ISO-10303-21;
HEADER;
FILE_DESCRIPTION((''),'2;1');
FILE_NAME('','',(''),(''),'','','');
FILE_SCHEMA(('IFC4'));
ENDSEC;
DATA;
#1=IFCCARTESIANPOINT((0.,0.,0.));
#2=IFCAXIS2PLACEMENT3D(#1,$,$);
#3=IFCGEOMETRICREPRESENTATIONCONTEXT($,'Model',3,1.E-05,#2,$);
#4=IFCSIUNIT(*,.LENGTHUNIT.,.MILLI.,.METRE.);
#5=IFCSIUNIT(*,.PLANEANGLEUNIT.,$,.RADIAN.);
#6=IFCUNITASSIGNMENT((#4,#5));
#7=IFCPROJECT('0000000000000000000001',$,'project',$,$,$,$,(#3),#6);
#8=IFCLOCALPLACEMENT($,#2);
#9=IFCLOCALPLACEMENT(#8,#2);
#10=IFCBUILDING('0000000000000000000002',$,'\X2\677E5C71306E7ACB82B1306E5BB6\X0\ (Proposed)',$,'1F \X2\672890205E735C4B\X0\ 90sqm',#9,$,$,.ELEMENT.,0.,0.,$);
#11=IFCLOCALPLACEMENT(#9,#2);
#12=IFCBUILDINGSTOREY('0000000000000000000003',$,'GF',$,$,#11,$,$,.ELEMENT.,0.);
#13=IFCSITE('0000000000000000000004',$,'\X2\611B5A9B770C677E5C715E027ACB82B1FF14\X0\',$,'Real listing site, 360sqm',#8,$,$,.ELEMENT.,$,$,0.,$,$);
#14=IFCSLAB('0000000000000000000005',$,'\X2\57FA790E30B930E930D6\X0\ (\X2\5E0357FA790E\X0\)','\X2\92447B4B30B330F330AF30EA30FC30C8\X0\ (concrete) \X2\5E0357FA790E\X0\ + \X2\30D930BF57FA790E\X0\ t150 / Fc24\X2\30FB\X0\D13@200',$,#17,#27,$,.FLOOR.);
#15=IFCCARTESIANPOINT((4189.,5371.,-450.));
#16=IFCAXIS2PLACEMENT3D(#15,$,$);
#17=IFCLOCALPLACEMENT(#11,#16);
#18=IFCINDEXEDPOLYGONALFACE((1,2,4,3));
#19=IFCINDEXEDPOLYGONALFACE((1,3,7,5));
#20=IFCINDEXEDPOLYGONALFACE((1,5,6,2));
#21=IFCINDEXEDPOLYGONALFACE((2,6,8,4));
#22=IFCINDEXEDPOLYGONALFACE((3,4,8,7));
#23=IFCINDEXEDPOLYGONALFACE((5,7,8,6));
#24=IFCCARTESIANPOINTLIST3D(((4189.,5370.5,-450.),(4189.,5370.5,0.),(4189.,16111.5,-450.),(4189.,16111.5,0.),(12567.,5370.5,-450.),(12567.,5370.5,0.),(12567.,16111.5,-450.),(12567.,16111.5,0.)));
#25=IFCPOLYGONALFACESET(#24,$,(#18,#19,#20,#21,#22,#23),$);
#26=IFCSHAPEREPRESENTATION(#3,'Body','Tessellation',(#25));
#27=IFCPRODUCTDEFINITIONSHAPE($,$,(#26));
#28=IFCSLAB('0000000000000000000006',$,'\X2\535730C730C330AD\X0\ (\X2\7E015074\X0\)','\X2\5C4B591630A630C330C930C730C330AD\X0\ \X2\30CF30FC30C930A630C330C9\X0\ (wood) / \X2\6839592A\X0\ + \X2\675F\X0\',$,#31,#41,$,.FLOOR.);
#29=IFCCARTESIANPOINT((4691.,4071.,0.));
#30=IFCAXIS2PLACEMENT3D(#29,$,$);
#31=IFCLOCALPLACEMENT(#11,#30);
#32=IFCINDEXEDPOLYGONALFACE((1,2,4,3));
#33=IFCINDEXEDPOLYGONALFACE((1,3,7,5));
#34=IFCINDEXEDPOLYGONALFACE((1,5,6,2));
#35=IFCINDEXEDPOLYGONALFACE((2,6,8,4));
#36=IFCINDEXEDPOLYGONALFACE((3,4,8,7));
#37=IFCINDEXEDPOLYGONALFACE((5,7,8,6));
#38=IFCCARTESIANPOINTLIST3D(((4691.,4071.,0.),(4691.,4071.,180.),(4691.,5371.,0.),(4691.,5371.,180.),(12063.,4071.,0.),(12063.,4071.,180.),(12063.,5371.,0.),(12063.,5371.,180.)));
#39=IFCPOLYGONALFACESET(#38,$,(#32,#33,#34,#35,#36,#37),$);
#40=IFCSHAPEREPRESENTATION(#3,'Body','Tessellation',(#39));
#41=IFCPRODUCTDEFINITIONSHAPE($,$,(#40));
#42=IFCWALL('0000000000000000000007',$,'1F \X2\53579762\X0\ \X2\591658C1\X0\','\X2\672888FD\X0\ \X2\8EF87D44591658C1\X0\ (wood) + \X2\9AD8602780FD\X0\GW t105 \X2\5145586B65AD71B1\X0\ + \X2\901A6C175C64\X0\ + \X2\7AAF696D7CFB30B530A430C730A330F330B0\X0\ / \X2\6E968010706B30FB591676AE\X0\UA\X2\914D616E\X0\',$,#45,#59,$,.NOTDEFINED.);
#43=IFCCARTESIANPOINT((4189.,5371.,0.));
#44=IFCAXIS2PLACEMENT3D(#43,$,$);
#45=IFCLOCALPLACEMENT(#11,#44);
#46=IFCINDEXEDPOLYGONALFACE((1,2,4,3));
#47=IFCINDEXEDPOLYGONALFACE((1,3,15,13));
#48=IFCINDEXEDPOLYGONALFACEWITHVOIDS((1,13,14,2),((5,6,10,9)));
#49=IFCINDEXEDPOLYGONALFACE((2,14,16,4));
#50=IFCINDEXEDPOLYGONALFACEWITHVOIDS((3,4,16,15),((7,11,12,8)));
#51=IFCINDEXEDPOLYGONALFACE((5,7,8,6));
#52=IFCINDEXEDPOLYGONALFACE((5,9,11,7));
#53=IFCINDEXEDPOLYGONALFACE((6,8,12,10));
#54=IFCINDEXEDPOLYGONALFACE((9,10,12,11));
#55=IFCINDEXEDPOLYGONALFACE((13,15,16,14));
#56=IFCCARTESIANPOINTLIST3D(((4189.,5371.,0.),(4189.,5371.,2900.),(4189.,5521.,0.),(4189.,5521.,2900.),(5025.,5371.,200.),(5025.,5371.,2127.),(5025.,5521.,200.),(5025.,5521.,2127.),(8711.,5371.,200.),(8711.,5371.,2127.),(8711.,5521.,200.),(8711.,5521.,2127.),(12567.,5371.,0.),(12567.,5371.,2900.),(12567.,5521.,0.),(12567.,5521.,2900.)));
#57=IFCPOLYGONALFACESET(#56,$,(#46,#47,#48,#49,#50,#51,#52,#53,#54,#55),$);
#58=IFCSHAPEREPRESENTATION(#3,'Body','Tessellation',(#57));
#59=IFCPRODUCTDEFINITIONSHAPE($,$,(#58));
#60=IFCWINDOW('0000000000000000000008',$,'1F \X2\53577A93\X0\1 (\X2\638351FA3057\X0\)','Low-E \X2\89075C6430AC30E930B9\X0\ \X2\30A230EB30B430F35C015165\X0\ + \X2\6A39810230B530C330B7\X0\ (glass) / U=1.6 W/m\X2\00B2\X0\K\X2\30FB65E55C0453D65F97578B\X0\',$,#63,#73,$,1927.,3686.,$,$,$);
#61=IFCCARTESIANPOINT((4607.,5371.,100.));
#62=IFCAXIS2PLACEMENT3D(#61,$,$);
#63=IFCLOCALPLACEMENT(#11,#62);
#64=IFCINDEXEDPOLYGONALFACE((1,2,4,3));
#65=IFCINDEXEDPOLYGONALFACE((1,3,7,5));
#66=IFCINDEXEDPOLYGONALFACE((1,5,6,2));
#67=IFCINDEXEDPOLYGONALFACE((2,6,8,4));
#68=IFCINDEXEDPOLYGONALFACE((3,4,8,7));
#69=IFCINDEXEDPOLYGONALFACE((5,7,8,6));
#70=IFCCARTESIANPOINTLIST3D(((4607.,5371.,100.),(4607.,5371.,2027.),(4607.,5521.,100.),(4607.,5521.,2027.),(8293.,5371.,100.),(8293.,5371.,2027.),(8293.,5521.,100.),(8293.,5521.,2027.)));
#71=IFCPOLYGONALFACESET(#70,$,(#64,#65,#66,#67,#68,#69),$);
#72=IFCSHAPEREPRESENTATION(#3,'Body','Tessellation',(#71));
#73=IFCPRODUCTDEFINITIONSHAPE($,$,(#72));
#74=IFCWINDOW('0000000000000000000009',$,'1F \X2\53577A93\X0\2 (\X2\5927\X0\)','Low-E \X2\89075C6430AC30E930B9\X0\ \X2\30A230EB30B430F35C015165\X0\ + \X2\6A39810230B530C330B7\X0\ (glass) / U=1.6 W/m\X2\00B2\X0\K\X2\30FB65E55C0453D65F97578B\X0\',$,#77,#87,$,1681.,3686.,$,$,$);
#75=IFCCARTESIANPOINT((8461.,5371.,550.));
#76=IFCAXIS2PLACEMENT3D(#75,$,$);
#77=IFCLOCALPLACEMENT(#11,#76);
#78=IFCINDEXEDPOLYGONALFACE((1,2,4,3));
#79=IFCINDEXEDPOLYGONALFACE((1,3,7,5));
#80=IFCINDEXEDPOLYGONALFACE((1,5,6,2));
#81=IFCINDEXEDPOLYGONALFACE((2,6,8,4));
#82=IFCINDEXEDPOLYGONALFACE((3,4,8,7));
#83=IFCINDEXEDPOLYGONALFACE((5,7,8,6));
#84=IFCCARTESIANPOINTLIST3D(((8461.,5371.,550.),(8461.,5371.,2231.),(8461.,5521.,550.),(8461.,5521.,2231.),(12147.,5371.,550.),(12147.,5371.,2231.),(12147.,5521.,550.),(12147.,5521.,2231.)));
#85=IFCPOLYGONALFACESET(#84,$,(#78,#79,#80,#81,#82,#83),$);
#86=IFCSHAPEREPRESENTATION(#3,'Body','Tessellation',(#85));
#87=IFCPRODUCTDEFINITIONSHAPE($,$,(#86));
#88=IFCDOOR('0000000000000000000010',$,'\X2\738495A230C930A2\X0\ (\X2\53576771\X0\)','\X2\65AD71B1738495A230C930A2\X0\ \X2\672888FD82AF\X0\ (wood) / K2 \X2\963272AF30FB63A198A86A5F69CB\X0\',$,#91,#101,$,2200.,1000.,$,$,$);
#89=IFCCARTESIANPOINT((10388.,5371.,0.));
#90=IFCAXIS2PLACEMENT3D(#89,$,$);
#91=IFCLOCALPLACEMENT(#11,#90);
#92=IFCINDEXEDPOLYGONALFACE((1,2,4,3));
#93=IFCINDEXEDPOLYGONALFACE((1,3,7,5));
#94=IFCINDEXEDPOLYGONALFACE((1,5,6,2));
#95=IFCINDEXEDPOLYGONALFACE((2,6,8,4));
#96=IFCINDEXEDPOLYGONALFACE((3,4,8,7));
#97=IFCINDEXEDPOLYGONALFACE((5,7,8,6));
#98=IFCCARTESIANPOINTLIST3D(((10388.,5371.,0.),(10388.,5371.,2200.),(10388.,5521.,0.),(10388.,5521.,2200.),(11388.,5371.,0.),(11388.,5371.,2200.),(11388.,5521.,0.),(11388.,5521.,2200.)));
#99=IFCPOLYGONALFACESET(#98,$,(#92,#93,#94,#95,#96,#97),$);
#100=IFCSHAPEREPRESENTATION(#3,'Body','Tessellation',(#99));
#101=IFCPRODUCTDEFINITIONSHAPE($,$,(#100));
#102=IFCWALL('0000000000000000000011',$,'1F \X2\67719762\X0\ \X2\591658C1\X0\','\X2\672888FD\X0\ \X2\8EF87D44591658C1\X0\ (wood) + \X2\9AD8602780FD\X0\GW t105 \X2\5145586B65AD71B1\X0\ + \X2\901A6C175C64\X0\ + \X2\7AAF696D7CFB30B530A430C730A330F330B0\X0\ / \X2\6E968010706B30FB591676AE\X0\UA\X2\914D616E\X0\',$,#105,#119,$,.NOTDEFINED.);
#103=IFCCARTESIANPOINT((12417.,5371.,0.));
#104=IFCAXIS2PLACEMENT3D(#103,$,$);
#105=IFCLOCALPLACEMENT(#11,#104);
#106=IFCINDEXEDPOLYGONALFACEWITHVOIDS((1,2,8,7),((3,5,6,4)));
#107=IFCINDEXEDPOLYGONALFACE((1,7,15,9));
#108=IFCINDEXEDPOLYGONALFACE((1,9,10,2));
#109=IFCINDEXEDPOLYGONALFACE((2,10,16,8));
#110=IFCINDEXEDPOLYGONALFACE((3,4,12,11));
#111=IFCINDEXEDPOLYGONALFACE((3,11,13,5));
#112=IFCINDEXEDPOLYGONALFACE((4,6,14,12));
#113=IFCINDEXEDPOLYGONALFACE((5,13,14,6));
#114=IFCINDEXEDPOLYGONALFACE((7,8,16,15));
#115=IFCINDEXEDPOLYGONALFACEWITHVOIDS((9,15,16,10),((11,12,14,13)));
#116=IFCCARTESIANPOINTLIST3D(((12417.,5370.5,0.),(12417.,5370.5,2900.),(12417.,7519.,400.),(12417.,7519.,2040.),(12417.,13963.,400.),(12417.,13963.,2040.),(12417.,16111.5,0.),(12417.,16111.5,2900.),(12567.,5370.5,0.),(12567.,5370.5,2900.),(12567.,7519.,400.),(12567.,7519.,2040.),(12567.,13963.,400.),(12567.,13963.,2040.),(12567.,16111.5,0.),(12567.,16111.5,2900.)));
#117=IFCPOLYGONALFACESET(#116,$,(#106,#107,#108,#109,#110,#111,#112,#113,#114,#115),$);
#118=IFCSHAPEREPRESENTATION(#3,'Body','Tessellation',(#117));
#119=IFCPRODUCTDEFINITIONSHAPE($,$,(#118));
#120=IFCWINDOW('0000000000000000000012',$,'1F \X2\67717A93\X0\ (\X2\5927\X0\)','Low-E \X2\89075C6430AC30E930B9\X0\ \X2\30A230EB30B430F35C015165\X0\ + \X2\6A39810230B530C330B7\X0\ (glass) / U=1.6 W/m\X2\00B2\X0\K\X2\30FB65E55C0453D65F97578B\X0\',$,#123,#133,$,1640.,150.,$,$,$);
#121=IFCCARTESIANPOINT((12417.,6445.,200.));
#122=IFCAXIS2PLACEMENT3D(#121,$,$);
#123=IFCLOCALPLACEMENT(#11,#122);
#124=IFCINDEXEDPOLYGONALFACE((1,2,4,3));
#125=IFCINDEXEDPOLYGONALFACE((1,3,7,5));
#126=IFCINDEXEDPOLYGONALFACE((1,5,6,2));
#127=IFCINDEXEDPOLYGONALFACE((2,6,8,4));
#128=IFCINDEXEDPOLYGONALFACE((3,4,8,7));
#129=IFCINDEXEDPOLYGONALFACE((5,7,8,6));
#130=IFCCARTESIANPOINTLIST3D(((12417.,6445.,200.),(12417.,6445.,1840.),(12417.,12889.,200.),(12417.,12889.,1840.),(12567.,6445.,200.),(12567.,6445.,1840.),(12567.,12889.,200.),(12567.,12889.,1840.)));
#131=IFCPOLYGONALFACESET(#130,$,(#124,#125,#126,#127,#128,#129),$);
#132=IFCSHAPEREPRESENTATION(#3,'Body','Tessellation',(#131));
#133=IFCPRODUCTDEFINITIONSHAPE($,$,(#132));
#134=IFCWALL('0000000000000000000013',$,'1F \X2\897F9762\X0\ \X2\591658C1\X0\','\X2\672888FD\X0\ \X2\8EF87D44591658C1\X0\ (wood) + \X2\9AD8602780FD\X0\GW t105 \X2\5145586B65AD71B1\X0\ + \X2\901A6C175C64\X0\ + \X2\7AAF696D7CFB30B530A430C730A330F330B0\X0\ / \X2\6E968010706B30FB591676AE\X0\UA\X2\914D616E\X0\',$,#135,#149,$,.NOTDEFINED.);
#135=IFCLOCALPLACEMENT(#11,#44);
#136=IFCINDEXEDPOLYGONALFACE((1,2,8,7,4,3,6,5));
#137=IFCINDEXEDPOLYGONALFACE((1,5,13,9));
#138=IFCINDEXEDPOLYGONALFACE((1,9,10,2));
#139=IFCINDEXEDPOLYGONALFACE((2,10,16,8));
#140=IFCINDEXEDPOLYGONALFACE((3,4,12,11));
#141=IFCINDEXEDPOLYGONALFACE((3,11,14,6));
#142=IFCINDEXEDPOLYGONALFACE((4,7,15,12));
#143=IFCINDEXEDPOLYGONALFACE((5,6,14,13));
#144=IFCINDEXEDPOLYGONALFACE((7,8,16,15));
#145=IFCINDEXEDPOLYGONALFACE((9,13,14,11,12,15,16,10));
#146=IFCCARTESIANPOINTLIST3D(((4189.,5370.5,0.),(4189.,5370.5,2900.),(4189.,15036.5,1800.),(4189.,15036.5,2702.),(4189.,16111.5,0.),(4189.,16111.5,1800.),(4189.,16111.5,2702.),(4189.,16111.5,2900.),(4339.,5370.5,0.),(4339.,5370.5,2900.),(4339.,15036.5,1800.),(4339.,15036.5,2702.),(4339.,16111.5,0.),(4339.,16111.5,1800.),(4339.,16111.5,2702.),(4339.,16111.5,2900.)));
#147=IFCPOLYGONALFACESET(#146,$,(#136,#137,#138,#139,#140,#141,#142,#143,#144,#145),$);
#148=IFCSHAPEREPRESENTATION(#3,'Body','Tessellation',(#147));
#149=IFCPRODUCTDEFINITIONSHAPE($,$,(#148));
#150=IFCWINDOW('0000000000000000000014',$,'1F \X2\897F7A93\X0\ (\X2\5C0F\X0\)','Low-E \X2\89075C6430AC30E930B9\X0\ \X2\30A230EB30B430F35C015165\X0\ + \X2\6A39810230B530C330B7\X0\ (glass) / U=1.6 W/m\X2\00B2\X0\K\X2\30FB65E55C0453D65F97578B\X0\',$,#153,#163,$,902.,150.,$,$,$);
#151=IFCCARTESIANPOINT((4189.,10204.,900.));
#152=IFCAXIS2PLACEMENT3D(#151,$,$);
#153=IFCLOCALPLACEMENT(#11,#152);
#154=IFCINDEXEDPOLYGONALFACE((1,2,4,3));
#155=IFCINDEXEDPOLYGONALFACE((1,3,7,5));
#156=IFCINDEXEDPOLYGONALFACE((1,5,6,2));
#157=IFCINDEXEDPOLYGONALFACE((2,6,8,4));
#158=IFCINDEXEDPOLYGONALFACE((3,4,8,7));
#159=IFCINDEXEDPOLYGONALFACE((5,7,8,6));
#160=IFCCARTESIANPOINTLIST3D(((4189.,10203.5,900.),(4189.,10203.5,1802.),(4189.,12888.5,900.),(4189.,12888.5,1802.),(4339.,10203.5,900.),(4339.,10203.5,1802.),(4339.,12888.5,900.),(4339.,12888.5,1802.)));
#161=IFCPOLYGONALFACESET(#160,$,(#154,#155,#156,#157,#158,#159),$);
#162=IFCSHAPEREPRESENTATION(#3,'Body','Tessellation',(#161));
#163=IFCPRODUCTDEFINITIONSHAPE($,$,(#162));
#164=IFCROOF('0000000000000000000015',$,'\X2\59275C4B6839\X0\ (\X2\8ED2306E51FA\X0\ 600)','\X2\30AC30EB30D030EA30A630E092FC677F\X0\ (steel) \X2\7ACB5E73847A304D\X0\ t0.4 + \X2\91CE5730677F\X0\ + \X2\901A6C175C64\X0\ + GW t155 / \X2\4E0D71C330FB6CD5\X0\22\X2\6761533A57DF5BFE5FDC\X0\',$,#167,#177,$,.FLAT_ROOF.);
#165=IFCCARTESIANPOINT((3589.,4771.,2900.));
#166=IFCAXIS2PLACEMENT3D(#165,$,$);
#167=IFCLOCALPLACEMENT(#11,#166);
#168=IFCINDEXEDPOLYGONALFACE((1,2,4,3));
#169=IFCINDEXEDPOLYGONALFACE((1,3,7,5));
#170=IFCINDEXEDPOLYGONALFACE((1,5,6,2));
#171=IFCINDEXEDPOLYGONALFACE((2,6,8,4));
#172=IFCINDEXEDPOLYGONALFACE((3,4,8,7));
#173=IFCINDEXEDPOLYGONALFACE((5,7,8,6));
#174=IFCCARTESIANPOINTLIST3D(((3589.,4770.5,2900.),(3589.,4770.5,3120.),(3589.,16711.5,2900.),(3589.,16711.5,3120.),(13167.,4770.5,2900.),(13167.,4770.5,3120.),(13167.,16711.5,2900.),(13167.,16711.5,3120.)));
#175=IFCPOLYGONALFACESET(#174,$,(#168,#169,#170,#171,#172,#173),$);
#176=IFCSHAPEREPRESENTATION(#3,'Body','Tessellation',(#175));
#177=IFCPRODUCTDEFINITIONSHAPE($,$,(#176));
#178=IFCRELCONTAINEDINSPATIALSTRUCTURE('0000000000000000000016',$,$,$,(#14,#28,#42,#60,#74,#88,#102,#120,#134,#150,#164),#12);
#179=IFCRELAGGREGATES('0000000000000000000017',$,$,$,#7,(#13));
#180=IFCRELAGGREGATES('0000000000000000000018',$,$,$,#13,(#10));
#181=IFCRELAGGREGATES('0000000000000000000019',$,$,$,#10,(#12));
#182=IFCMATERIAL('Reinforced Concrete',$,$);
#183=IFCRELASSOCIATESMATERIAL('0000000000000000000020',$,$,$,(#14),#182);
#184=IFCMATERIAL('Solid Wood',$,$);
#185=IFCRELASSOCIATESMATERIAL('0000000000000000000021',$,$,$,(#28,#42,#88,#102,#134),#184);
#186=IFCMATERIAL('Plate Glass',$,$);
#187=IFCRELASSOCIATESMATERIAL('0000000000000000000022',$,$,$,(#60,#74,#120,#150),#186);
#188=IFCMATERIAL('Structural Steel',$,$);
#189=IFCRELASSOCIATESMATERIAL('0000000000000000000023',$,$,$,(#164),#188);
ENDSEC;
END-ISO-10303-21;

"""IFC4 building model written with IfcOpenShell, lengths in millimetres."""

from ifc_helpers import new_model, si_unit, frame, frame_2d, origin, place, context, project, spatial, rectangle, extrude, material, element, fill, save


model = new_model("IFC4")

# Units and contexts
model_context = context("Model", 3, precision=1e-05, world=origin())
ifc_project = project(units=[si_unit("LENGTHUNIT", "METRE", prefix="MILLI"), si_unit("PLANEANGLEUNIT", "RADIAN")], contexts=[model_context])

# Site, building, storey
site_placement = place(None, origin())
site = spatial("IfcSite", under=ifc_project, at=site_placement, Name="愛媛県松山市立花４", ObjectType="Real listing site, 360sqm", CompositionType="ELEMENT", RefElevation=0.0)
building_placement = place(site_placement, origin())
building = spatial("IfcBuilding", under=site, at=building_placement, Name="松山の立花の家 (Proposed)", ObjectType="1F 木造平屋 90sqm", CompositionType="ELEMENT", ElevationOfRefHeight=0.0, ElevationOfTerrain=0.0)
storey_placement = place(building_placement, origin())
storey = spatial("IfcBuildingStorey", under=building, at=storey_placement, Name="GF", CompositionType="ELEMENT", Elevation=0.0)

# Slabs
ifc_material_1 = material(Name="Reinforced Concrete")
slab_1_placement = place(storey_placement, frame((4189.0, 5371.0, -450.0)))
element("IfcSlab", 1, at=slab_1_placement, inside=storey, material=ifc_material_1, Name="基礎スラブ (布基礎)", Description="鉄筋コンクリート (concrete) 布基礎 + ベタ基礎 t150 / Fc24・D13@200", PredefinedType="FLOOR", context=model_context, shape_type="SweptSolid", body=[
    extrude(rectangle(XDim=8378.0, YDim=10741.0, at=frame_2d((4189.0, 5370.0))), frame((4189.0, 5371.0, -450.0)), (0.0, 0.0, 1.0), 450.0),
])
ifc_material_2 = material(Name="Solid Wood")
slab_2_placement = place(storey_placement, frame((4691.0, 4071.0, 0.0)))
element("IfcSlab", 2, at=slab_2_placement, inside=storey, material=ifc_material_2, Name="南デッキ (縁側)", Description="屋外ウッドデッキ ハードウッド (wood) / 根太 + 束", PredefinedType="FLOOR", context=model_context, shape_type="SweptSolid", body=[
    extrude(rectangle(XDim=7372.0, YDim=1300.0, at=frame_2d((3686.0, 650.0))), frame((4691.0, 4071.0, 0.0)), (0.0, 0.0, 1.0), 180.0),
])

# Wall, openings, windows, door
wall_1_placement = place(storey_placement, frame((4189.0, 5371.0, 0.0)))
wall_1 = element("IfcWall", 3, at=wall_1_placement, inside=storey, material=ifc_material_2, Name="1F 南面 外壁", Description="木製 軸組外壁 (wood) + 高性能GW t105 充填断熱 + 通気層 + 窯業系サイディング / 準耐火・外皮UA配慮", PredefinedType="NOTDEFINED", context=model_context, shape_type="SweptSolid", body=[
    extrude(rectangle(XDim=8378.0, YDim=150.0, at=frame_2d((4189.0, 75.0))), frame((4189.0, 5371.0, 0.0)), (0.0, 0.0, 1.0), 2900.0),
])
opening_1_placement = place(storey_placement, frame((4607.0, 5371.0, 100.0)))
opening_1 = element("IfcOpeningElement", 4, at=opening_1_placement, cuts=wall_1, PredefinedType="NOTDEFINED", context=model_context, shape_type="SweptSolid", body=[
    extrude(rectangle(XDim=3686.0, YDim=150.0, at=frame_2d((1843.0, 75.0))), frame((4607.0, 5371.0, 100.0)), (0.0, 0.0, 1.0), 1927.0),
])
opening_2_placement = place(storey_placement, frame((8461.0, 5371.0, 550.0)))
opening_2 = element("IfcOpeningElement", 5, at=opening_2_placement, cuts=wall_1, PredefinedType="NOTDEFINED", context=model_context, shape_type="SweptSolid", body=[
    extrude(rectangle(XDim=3686.0, YDim=150.0, at=frame_2d((1843.0, 75.0))), frame((8461.0, 5371.0, 550.0)), (0.0, 0.0, 1.0), 1681.0),
])
opening_3_placement = place(storey_placement, frame((10388.0, 5371.0, 0.0)))
opening_3 = element("IfcOpeningElement", 6, at=opening_3_placement, cuts=wall_1, PredefinedType="NOTDEFINED", context=model_context, shape_type="SweptSolid", body=[
    extrude(rectangle(XDim=1000.0, YDim=150.0, at=frame_2d((500.0, 75.0))), frame((10388.0, 5371.0, 0.0)), (0.0, 0.0, 1.0), 2200.0),
])
ifc_material_3 = material(Name="Plate Glass")
window_1_placement = place(storey_placement, frame((4607.0, 5371.0, 100.0)))
window_1 = element("IfcWindow", 7, at=window_1_placement, inside=storey, material=ifc_material_3, Name="1F 南窓1 (掃出し)", Description="Low-E 複層ガラス アルゴン封入 + 樹脂サッシ (glass) / U=1.6 W/m²K・日射取得型", OverallHeight=1927.0, OverallWidth=3686.0, context=model_context, shape_type="SweptSolid", body=[
    extrude(rectangle(XDim=3686.0, YDim=150.0, at=frame_2d((1843.0, 75.0))), frame((4607.0, 5371.0, 100.0)), (0.0, 0.0, 1.0), 1927.0),
])
fill(opening_1, window_1)
window_2_placement = place(storey_placement, frame((8461.0, 5371.0, 550.0)))
window_2 = element("IfcWindow", 8, at=window_2_placement, inside=storey, material=ifc_material_3, Name="1F 南窓2 (大)", Description="Low-E 複層ガラス アルゴン封入 + 樹脂サッシ (glass) / U=1.6 W/m²K・日射取得型", OverallHeight=1681.0, OverallWidth=3686.0, context=model_context, shape_type="SweptSolid", body=[
    extrude(rectangle(XDim=3686.0, YDim=150.0, at=frame_2d((1843.0, 75.0))), frame((8461.0, 5371.0, 550.0)), (0.0, 0.0, 1.0), 1681.0),
])
fill(opening_2, window_2)
door_placement = place(storey_placement, frame((10388.0, 5371.0, 0.0)))
door = element("IfcDoor", 9, at=door_placement, inside=storey, material=ifc_material_2, Name="玄関ドア (南東)", Description="断熱玄関ドア 木製芯 (wood) / K2 防犯・採風機構", OverallHeight=2200.0, OverallWidth=1000.0, context=model_context, shape_type="SweptSolid", body=[
    extrude(rectangle(XDim=1000.0, YDim=150.0, at=frame_2d((500.0, 75.0))), frame((10388.0, 5371.0, 0.0)), (0.0, 0.0, 1.0), 2200.0),
])
fill(opening_3, door)

# Walls, openings, windows
wall_2_placement = place(storey_placement, frame((12417.0, 5371.0, 0.0)))
wall_2 = element("IfcWall", 10, at=wall_2_placement, inside=storey, material=ifc_material_2, Name="1F 東面 外壁", Description="木製 軸組外壁 (wood) + 高性能GW t105 充填断熱 + 通気層 + 窯業系サイディング / 準耐火・外皮UA配慮", PredefinedType="NOTDEFINED", context=model_context, shape_type="SweptSolid", body=[
    extrude(rectangle(XDim=150.0, YDim=10741.0, at=frame_2d((75.0, 5370.0))), frame((12417.0, 5371.0, 0.0)), (0.0, 0.0, 1.0), 2900.0),
])
opening_4_placement = place(storey_placement, frame((12417.0, 6445.0, 200.0)))
opening_4 = element("IfcOpeningElement", 11, at=opening_4_placement, cuts=wall_2, PredefinedType="NOTDEFINED", context=model_context, shape_type="SweptSolid", body=[
    extrude(rectangle(XDim=150.0, YDim=6444.0, at=frame_2d((75.0, 3222.0))), frame((12417.0, 6445.0, 200.0)), (0.0, 0.0, 1.0), 1640.0),
])
window_3_placement = place(storey_placement, frame((12417.0, 6445.0, 200.0)))
window_3 = element("IfcWindow", 12, at=window_3_placement, inside=storey, material=ifc_material_3, Name="1F 東窓 (大)", Description="Low-E 複層ガラス アルゴン封入 + 樹脂サッシ (glass) / U=1.6 W/m²K・日射取得型", OverallHeight=1640.0, OverallWidth=150.0, context=model_context, shape_type="SweptSolid", body=[
    extrude(rectangle(XDim=150.0, YDim=6444.0, at=frame_2d((75.0, 3222.0))), frame((12417.0, 6445.0, 200.0)), (0.0, 0.0, 1.0), 1640.0),
])
fill(opening_4, window_3)
wall_3_placement = place(storey_placement, frame((4189.0, 5371.0, 0.0)))
wall_3 = element("IfcWall", 13, at=wall_3_placement, inside=storey, material=ifc_material_2, Name="1F 西面 外壁", Description="木製 軸組外壁 (wood) + 高性能GW t105 充填断熱 + 通気層 + 窯業系サイディング / 準耐火・外皮UA配慮", PredefinedType="NOTDEFINED", context=model_context, shape_type="SweptSolid", body=[
    extrude(rectangle(XDim=150.0, YDim=10741.0, at=frame_2d((75.0, 5370.0))), frame((4189.0, 5371.0, 0.0)), (0.0, 0.0, 1.0), 2900.0),
])
opening_5_placement = place(storey_placement, frame((4189.0, 10204.0, 900.0)))
opening_5 = element("IfcOpeningElement", 14, at=opening_5_placement, cuts=wall_3, PredefinedType="NOTDEFINED", context=model_context, shape_type="SweptSolid", body=[
    extrude(rectangle(XDim=150.0, YDim=2685.0, at=frame_2d((75.0, 1342.0))), frame((4189.0, 10204.0, 900.0)), (0.0, 0.0, 1.0), 902.0),
])
window_4_placement = place(storey_placement, frame((4189.0, 10204.0, 900.0)))
window_4 = element("IfcWindow", 15, at=window_4_placement, inside=storey, material=ifc_material_3, Name="1F 西窓 (小)", Description="Low-E 複層ガラス アルゴン封入 + 樹脂サッシ (glass) / U=1.6 W/m²K・日射取得型", OverallHeight=902.0, OverallWidth=150.0, context=model_context, shape_type="SweptSolid", body=[
    extrude(rectangle(XDim=150.0, YDim=2685.0, at=frame_2d((75.0, 1342.0))), frame((4189.0, 10204.0, 900.0)), (0.0, 0.0, 1.0), 902.0),
])
fill(opening_5, window_4)

# Roof
ifc_material_4 = material(Name="Structural Steel")
roof_placement = place(storey_placement, frame((3589.0, 4771.0, 2900.0)))
element("IfcRoof", 16, at=roof_placement, inside=storey, material=ifc_material_4, Name="大屋根 (軒の出 600)", Description="ガルバリウム鋼板 (steel) 立平葺き t0.4 + 野地板 + 通気層 + GW t155 / 不燃・法22条区域対応", PredefinedType="FLAT_ROOF", context=model_context, shape_type="SweptSolid", body=[
    extrude(rectangle(XDim=9578.0, YDim=11941.0, at=frame_2d((4789.0, 5970.0))), frame((3589.0, 4771.0, 2900.0)), (0.0, 0.0, 1.0), 220.0),
])

save(model, "model.ifc")
